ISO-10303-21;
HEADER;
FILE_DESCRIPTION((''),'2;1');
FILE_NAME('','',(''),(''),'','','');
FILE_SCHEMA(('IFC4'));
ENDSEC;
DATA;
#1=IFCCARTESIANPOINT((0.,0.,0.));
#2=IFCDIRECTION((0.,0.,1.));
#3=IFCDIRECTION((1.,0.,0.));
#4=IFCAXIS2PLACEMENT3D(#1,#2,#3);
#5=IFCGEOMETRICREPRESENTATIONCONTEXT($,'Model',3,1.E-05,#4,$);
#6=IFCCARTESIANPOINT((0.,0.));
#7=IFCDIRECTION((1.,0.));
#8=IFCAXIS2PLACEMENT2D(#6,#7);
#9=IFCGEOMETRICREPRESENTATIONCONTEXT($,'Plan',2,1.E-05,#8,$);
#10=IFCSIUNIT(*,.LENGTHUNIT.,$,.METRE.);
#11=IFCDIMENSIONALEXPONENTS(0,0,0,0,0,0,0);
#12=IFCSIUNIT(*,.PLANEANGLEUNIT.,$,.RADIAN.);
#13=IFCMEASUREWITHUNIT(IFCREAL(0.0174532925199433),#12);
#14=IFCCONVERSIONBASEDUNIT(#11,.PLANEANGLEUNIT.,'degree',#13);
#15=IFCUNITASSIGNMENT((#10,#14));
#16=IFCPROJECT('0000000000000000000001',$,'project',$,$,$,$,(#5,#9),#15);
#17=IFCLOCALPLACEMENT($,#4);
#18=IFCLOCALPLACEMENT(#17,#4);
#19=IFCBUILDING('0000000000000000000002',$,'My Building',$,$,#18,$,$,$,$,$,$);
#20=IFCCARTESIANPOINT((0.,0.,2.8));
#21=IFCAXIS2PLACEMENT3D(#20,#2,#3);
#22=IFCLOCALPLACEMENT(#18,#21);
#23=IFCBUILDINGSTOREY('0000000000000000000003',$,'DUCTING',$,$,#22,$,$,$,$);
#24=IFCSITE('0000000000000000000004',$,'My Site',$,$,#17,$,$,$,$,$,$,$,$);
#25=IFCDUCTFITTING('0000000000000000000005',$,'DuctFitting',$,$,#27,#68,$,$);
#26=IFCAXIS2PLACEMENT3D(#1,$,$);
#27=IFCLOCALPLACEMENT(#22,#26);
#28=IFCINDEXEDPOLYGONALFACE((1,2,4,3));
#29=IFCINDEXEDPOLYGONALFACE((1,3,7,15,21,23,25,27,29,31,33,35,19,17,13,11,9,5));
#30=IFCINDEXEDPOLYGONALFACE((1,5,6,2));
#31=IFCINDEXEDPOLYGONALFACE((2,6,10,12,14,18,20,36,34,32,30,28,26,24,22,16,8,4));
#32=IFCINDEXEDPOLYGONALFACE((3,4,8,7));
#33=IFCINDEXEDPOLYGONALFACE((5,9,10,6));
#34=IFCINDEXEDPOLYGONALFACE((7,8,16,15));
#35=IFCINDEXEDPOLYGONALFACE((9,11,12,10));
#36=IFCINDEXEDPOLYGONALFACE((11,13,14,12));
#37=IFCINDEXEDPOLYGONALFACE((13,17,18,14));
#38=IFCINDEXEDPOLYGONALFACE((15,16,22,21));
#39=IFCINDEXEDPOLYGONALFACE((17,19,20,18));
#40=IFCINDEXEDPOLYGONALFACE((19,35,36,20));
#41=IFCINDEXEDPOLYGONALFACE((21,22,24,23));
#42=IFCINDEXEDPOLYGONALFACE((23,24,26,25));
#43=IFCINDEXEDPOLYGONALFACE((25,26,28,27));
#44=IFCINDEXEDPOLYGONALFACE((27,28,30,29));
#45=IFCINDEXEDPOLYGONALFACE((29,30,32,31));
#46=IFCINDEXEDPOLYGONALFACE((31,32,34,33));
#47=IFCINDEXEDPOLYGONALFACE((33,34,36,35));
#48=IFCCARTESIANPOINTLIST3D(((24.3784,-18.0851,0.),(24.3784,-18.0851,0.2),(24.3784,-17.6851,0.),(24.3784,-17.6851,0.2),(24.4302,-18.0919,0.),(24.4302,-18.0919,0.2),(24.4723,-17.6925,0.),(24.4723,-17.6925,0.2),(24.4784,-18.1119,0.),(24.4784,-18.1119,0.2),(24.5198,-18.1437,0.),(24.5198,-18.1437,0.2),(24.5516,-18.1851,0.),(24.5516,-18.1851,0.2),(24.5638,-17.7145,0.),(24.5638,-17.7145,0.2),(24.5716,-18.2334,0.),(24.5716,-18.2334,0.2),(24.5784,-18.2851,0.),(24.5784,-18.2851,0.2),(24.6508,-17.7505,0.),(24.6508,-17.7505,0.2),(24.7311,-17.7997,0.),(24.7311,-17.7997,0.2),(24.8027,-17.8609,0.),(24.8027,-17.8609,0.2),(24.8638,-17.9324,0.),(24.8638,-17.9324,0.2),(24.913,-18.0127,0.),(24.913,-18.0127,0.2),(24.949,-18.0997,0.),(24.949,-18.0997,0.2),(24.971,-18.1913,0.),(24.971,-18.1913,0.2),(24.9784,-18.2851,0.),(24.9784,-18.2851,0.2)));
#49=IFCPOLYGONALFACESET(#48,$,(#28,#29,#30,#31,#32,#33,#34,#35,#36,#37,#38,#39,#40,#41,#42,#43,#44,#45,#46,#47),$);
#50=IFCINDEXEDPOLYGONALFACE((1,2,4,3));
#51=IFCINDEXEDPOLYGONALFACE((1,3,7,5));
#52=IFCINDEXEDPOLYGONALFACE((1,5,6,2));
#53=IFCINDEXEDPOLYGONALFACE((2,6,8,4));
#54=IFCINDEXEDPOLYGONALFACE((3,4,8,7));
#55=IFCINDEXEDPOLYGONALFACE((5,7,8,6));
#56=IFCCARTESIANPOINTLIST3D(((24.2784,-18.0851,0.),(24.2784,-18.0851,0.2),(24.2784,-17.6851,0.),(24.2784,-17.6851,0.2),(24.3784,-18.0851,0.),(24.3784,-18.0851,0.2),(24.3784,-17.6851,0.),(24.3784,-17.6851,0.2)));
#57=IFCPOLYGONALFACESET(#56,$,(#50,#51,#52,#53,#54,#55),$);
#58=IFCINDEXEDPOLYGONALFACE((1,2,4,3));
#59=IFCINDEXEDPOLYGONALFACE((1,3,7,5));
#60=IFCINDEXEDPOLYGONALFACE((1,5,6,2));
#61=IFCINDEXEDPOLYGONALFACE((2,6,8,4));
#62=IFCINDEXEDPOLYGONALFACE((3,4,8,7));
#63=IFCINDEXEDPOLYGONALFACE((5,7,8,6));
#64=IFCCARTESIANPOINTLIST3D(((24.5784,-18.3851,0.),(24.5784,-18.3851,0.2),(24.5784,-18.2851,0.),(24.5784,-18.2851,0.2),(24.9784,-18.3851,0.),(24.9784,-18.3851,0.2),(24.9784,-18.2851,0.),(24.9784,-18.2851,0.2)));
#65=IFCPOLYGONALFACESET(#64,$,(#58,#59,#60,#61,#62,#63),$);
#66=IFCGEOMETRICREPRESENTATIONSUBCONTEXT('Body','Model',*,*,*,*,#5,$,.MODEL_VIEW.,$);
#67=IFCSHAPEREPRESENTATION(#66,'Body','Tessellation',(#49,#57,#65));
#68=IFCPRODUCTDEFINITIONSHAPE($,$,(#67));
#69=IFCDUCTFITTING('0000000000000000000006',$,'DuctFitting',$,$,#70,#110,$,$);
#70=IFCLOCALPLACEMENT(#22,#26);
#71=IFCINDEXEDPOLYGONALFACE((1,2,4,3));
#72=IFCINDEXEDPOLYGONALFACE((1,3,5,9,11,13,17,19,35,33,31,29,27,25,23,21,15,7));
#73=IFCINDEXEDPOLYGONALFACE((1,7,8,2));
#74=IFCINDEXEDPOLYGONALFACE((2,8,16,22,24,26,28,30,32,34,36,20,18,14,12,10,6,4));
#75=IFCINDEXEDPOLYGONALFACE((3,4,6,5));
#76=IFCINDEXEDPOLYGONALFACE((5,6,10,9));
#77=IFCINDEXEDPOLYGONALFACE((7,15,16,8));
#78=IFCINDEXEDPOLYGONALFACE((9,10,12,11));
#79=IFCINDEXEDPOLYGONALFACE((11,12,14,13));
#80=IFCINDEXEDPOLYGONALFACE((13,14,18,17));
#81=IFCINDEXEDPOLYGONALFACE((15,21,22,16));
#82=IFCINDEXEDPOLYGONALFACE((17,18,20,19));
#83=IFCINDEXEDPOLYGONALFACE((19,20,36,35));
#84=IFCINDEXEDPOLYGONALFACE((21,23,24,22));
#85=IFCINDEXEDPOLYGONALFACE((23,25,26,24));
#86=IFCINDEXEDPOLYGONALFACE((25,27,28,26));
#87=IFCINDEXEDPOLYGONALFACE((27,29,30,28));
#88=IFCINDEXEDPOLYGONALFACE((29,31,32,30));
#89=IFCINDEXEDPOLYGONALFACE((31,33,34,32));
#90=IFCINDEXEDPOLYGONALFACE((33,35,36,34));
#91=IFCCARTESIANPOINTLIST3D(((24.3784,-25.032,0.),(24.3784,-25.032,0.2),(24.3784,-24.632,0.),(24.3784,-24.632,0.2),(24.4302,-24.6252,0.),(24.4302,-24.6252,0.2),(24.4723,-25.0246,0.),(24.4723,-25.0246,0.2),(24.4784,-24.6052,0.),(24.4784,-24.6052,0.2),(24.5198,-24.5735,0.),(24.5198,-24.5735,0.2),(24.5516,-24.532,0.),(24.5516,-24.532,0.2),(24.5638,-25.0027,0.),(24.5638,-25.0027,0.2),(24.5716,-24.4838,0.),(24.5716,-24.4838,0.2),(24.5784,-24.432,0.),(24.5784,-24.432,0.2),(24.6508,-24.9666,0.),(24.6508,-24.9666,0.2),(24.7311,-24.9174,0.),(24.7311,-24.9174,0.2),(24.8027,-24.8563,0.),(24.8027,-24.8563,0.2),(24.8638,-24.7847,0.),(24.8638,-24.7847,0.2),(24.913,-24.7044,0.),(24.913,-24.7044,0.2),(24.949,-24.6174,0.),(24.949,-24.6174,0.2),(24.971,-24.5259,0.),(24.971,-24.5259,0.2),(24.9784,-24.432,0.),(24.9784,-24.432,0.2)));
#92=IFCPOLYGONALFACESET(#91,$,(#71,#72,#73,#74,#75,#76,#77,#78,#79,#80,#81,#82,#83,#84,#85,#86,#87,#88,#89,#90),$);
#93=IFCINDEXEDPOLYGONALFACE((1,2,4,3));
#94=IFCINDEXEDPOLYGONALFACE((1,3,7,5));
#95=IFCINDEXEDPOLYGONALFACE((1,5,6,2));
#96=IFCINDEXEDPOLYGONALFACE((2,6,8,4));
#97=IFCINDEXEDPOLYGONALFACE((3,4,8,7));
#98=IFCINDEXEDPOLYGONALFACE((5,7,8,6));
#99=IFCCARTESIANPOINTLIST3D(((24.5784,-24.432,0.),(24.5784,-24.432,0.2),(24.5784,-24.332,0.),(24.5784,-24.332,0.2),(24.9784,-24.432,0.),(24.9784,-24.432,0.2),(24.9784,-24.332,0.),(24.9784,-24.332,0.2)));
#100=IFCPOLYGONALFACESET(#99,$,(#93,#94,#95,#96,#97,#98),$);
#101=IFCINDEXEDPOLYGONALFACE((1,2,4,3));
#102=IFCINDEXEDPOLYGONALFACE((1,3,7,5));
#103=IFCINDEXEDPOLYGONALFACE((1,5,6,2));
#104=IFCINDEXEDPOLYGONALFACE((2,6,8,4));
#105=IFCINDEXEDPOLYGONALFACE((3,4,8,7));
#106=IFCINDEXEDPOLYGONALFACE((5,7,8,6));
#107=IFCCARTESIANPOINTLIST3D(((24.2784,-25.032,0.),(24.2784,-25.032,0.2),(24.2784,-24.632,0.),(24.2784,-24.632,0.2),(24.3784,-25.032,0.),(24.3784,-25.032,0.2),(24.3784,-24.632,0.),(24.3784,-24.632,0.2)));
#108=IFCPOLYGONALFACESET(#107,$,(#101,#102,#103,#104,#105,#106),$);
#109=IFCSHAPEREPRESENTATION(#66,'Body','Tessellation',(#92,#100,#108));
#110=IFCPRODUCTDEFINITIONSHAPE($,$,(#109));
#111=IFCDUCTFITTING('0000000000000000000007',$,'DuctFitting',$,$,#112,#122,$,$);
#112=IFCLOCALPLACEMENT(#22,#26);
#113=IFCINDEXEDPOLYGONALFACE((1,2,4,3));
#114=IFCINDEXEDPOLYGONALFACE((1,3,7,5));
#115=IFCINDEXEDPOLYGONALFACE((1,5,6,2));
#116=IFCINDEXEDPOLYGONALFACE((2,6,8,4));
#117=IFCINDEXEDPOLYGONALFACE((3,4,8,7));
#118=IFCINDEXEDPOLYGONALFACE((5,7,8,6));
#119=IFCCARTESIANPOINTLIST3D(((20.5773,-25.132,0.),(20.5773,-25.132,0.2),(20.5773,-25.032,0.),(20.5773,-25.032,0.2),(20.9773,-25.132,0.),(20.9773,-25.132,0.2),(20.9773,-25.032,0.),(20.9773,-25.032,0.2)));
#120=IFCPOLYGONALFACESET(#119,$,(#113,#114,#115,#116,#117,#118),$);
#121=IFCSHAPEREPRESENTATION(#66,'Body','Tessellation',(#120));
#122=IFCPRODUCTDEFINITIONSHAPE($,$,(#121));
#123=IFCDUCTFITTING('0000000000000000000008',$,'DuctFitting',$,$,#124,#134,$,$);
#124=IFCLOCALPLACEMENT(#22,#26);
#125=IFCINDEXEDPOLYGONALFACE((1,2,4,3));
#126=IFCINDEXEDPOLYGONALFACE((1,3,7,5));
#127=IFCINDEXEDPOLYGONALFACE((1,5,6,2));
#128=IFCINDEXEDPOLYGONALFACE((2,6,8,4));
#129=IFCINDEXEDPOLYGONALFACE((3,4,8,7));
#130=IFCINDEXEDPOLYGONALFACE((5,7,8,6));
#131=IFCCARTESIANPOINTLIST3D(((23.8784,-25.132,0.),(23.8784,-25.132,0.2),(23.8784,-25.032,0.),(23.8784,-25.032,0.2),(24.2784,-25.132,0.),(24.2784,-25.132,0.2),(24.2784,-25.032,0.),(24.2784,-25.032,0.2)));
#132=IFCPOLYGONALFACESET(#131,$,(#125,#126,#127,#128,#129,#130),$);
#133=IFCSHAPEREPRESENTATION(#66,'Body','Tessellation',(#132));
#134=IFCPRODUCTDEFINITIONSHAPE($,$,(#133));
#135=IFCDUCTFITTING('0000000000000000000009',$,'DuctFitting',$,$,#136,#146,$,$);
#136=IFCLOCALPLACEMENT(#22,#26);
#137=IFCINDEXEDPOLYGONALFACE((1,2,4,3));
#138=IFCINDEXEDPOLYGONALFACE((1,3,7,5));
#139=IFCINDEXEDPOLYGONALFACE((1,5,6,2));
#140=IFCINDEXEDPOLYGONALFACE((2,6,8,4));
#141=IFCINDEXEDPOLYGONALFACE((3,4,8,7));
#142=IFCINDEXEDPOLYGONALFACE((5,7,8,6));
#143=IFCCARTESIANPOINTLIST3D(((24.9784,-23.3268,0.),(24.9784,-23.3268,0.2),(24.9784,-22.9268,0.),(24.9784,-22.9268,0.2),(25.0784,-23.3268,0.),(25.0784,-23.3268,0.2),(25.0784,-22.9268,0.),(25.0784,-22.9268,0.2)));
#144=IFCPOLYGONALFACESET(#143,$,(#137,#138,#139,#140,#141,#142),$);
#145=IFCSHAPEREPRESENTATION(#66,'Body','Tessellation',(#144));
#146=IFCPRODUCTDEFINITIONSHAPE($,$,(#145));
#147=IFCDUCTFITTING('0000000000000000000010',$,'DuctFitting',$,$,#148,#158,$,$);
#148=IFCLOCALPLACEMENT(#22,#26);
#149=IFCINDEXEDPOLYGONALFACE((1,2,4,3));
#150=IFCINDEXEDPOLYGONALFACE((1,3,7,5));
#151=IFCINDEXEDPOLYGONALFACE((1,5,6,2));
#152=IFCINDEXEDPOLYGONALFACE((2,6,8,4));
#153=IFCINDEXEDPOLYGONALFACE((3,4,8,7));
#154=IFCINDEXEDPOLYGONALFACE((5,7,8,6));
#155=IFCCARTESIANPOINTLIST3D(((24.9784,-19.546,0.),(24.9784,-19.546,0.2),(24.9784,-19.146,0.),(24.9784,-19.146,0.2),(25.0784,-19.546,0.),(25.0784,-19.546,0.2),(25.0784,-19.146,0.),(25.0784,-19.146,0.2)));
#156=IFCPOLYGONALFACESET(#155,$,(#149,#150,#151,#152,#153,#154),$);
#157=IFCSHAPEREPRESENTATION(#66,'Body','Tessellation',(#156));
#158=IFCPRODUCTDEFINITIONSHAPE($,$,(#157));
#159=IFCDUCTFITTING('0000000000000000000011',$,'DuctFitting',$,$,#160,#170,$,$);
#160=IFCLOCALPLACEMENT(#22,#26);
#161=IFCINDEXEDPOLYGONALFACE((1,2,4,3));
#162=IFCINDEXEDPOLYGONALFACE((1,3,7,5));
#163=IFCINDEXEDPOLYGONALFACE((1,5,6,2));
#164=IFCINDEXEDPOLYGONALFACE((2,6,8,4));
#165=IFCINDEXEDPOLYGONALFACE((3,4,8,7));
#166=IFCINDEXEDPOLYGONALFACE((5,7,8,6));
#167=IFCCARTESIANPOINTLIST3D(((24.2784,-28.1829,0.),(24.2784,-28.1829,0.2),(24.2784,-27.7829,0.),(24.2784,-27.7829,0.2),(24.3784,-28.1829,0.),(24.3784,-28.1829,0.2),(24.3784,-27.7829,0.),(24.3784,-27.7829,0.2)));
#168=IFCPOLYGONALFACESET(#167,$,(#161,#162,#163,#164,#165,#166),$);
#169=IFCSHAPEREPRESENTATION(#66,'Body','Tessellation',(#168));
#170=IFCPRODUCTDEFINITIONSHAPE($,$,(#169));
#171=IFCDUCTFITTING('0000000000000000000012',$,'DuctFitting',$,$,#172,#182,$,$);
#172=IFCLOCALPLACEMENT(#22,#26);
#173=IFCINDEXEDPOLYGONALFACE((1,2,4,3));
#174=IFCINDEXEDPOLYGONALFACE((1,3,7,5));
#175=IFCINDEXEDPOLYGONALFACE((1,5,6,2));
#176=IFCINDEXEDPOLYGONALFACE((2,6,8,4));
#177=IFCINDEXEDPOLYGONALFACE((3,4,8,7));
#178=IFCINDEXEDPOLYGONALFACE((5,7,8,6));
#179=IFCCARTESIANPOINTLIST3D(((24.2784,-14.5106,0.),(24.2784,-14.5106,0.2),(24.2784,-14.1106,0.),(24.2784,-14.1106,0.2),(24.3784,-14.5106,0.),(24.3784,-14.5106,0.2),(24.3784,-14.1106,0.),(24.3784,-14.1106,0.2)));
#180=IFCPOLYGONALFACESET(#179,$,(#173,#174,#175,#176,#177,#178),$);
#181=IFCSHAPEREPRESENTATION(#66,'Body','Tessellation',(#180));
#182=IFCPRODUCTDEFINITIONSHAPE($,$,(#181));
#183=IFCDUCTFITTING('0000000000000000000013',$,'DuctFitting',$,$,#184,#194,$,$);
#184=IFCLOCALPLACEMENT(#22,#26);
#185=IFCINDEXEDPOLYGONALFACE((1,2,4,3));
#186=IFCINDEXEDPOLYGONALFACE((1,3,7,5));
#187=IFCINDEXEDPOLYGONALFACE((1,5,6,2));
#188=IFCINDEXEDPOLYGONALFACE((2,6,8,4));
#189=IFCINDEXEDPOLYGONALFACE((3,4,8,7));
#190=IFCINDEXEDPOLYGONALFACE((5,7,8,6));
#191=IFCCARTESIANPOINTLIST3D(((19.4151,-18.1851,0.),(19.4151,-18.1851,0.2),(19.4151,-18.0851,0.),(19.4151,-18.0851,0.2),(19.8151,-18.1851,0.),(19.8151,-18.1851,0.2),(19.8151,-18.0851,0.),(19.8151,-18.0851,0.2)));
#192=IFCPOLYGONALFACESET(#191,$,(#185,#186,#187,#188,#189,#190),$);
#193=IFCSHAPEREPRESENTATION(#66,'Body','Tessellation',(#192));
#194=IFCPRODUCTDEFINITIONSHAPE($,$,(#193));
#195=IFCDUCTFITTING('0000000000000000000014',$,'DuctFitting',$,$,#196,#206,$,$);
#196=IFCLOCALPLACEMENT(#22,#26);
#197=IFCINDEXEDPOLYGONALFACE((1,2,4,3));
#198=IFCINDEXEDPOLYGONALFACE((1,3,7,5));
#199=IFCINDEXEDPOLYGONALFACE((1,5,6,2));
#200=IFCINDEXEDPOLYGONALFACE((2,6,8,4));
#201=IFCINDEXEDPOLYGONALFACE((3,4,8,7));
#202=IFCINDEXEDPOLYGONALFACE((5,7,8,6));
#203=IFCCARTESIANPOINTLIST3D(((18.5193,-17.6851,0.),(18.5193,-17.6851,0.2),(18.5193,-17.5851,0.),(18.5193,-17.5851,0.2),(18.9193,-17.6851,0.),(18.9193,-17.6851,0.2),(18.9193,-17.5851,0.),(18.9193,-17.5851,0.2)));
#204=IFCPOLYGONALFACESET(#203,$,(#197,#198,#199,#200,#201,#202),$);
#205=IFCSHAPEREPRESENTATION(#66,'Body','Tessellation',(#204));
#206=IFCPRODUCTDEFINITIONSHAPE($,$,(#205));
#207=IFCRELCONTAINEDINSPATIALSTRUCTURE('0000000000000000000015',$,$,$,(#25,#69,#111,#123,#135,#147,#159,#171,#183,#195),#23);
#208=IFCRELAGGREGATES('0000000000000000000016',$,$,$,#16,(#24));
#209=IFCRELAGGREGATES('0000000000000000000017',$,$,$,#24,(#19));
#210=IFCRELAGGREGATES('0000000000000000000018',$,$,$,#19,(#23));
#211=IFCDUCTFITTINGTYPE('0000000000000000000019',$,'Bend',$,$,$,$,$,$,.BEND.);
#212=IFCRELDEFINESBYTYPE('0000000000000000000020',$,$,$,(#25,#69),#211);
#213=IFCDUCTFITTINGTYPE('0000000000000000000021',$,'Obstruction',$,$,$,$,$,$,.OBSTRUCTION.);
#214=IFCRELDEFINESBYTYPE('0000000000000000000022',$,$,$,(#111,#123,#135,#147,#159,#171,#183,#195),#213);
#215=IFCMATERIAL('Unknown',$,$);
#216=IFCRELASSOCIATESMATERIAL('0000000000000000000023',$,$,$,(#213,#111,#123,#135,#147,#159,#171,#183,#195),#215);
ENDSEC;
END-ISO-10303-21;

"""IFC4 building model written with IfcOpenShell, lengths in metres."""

from ifc_helpers import new_model, entity, si_unit, converted_unit, frame, origin_with_axes, origin_2d_with_axis, place, context, subcontext, project, spatial, line, arc, indexed_curve, rectangle, outline, extrude, source, transform, mapped, material, material_profile, profile_set, profile_usage, type_object, type_shapes, element, save


model = new_model("IFC4")

# Units and contexts
model_context = context("Model", 3, precision=1e-05, world=origin_with_axes())
plan_context = context("Plan", 2, precision=1e-05, world=origin_2d_with_axis())
body_context = subcontext(model_context, "Body", "Model", "MODEL_VIEW")
ifc_project = project(units=[si_unit("LENGTHUNIT", "METRE"), converted_unit("PLANEANGLEUNIT", "degree", entity("IfcReal", 0.0174532925199433), si_unit("PLANEANGLEUNIT", "RADIAN"), dimensions=[0, 0, 0, 0, 0, 0, 0])], contexts=[model_context, plan_context])

# Site, building, storey
site_placement = place(None, origin_with_axes())
site = spatial("IfcSite", under=ifc_project, at=site_placement, Name="My Site")
building_placement = place(site_placement, origin_with_axes())
building = spatial("IfcBuilding", under=site, at=building_placement, Name="My Building")
storey_placement = place(building_placement, frame((0.0, 0.0, 2.8), z_axis=(0.0, 0.0, 1.0), x_axis=(1.0, 0.0, 0.0)))
storey = spatial("IfcBuildingStorey", under=building, at=storey_placement, Name="DUCTING")

# Shared definitions
ifc_material = material(Name="Unknown")

# Duct fittings
duct_fitting_type_1 = type_object("IfcDuctFittingType", Name="Bend", PredefinedType="BEND")
shared_shape = source(origin_with_axes(), body_context, "Body", "SweptSolid", [
    extrude(outline(indexed_curve([(0.2, 0.0), (0.2586, -0.1414), (0.4, -0.2), (0.4, -0.6), (-0.0243, -0.4243), (-0.2, 0.0)], segments=[arc(1, 2, 3), line(3, 4), arc(4, 5, 6), line(6, 1)])), frame((0.0, -0.1, -0.1), z_axis=(0.0, -1.0, 0.0), x_axis=(1.0, 0.0, 0.0)), (0.0, 0.0, -1.0), 0.2),
    extrude(rectangle(XDim=0.4, YDim=0.2), origin_with_axes(), (0.0, 0.0, -1.0), 0.1),
    extrude(rectangle(XDim=0.4, YDim=0.2), frame((0.4, 0.0, -0.5), z_axis=(1.0, 0.0, 0.0), x_axis=(0.0, 0.0, 1.0)), (0.0, 0.0, 1.0), 0.1),
])
type_shapes(duct_fitting_type_1, [shared_shape])
for number, where, z_axis, x_axis, name in (
    (1, (24.2784, -17.8851, 0.1), (-1.0, 0.0, 0.000001), (0.0, -1.0, 0.0), "DuctFitting"),
    (2, (24.7784, -24.332, 0.1), (0.0, 1.0, 0.0), (-1.0, 0.0, 0.0), "DuctFitting"),
):
    element("IfcDuctFitting", number, at=place(storey_placement, frame(where, z_axis=z_axis, x_axis=x_axis)), inside=storey, type_object=duct_fitting_type_1, Name=name, context=body_context, shape_type="MappedRepresentation", body=[
        mapped(shared_shape, transform((0.0, 0.0, 0.0), x_axis=(1.0, 0.0, 0.0), y_axis=(0.0, 1.0, 0.0), z_axis=(0.0, 0.0, 1.0), scale=1.0)),
    ])
ifc_material_profile_1 = material_profile(ifc_material, rectangle(XDim=0.4, YDim=0.2))
ifc_profile_set_1 = profile_set([ifc_material_profile_1])
ifc_profile_usage_1 = profile_usage(ifc_profile_set_1, cardinal=5)
duct_fitting_type_2 = type_object("IfcDuctFittingType", Name="Obstruction", PredefinedType="OBSTRUCTION", material=ifc_profile_set_1)
duct_fitting_1_placement = place(storey_placement, frame((20.7773, -25.032, 0.1), z_axis=(0.0, -1.0, 0.0), x_axis=(1.0, 0.0, 0.0)))
element("IfcDuctFitting", 3, at=duct_fitting_1_placement, inside=storey, type_object=duct_fitting_type_2, material=ifc_profile_usage_1, Name="DuctFitting", context=body_context, shape_type="SweptSolid", body=[
    extrude(rectangle(XDim=0.4, YDim=0.2), origin_with_axes(), (0.0, 0.0, 1.0), 0.1),
])
ifc_profile_usage_2 = profile_usage(ifc_profile_set_1, cardinal=5)
duct_fitting_2_placement = place(storey_placement, frame((24.0784, -25.032, 0.1), z_axis=(0.0, -1.0, 0.0), x_axis=(1.0, 0.0, 0.0)))
element("IfcDuctFitting", 4, at=duct_fitting_2_placement, inside=storey, type_object=duct_fitting_type_2, material=ifc_profile_usage_2, Name="DuctFitting", context=body_context, shape_type="SweptSolid", body=[
    extrude(rectangle(XDim=0.4, YDim=0.2), origin_with_axes(), (0.0, 0.0, 1.0), 0.1),
])
ifc_profile_usage_3 = profile_usage(ifc_profile_set_1, cardinal=5)
duct_fitting_3_placement = place(storey_placement, frame((24.9784, -23.1268, 0.1), z_axis=(1.0, 0.0, 0.0), x_axis=(0.0, 1.0, 0.0)))
element("IfcDuctFitting", 5, at=duct_fitting_3_placement, inside=storey, type_object=duct_fitting_type_2, material=ifc_profile_usage_3, Name="DuctFitting", context=body_context, shape_type="SweptSolid", body=[
    extrude(rectangle(XDim=0.4, YDim=0.2), origin_with_axes(), (0.0, 0.0, 1.0), 0.1),
])
ifc_profile_usage_4 = profile_usage(ifc_profile_set_1, cardinal=5)
duct_fitting_4_placement = place(storey_placement, frame((24.9784, -19.346, 0.1), z_axis=(1.0, 0.0, 0.0), x_axis=(0.0, 1.0, 0.0)))
element("IfcDuctFitting", 6, at=duct_fitting_4_placement, inside=storey, type_object=duct_fitting_type_2, material=ifc_profile_usage_4, Name="DuctFitting", context=body_context, shape_type="SweptSolid", body=[
    extrude(rectangle(XDim=0.4, YDim=0.2), origin_with_axes(), (0.0, 0.0, 1.0), 0.1),
])
ifc_profile_usage_5 = profile_usage(ifc_profile_set_1, cardinal=5)
duct_fitting_5_placement = place(storey_placement, frame((24.2784, -27.9829, 0.1), z_axis=(1.0, 0.0, 0.0), x_axis=(0.0, 1.0, 0.0)))
element("IfcDuctFitting", 7, at=duct_fitting_5_placement, inside=storey, type_object=duct_fitting_type_2, material=ifc_profile_usage_5, Name="DuctFitting", context=body_context, shape_type="SweptSolid", body=[
    extrude(rectangle(XDim=0.4, YDim=0.2), origin_with_axes(), (0.0, 0.0, 1.0), 0.1),
])
ifc_profile_usage_6 = profile_usage(ifc_profile_set_1, cardinal=5)
duct_fitting_6_placement = place(storey_placement, frame((24.2784, -14.3106, 0.1), z_axis=(1.0, 0.0, 0.0), x_axis=(0.0, 1.0, 0.0)))
element("IfcDuctFitting", 8, at=duct_fitting_6_placement, inside=storey, type_object=duct_fitting_type_2, material=ifc_profile_usage_6, Name="DuctFitting", context=body_context, shape_type="SweptSolid", body=[
    extrude(rectangle(XDim=0.4, YDim=0.2), origin_with_axes(), (0.0, 0.0, 1.0), 0.1),
])
ifc_profile_usage_7 = profile_usage(ifc_profile_set_1, cardinal=5)
duct_fitting_7_placement = place(storey_placement, frame((19.6151, -18.0851, 0.1), z_axis=(0.0, -1.0, 0.0), x_axis=(1.0, 0.0, 0.0)))
element("IfcDuctFitting", 9, at=duct_fitting_7_placement, inside=storey, type_object=duct_fitting_type_2, material=ifc_profile_usage_7, Name="DuctFitting", context=body_context, shape_type="SweptSolid", body=[
    extrude(rectangle(XDim=0.4, YDim=0.2), origin_with_axes(), (0.0, 0.0, 1.0), 0.1),
])
ifc_profile_usage_8 = profile_usage(ifc_profile_set_1, cardinal=5)
duct_fitting_8_placement = place(storey_placement, frame((18.7193, -17.6851, 0.1), z_axis=(0.0, 1.0, 0.0), x_axis=(-1.0, 0.0, 0.0)))
element("IfcDuctFitting", 10, at=duct_fitting_8_placement, inside=storey, type_object=duct_fitting_type_2, material=ifc_profile_usage_8, Name="DuctFitting", context=body_context, shape_type="SweptSolid", body=[
    extrude(rectangle(XDim=0.4, YDim=0.2), origin_with_axes(), (0.0, 0.0, 1.0), 0.1),
])

save(model, "model.ifc")
